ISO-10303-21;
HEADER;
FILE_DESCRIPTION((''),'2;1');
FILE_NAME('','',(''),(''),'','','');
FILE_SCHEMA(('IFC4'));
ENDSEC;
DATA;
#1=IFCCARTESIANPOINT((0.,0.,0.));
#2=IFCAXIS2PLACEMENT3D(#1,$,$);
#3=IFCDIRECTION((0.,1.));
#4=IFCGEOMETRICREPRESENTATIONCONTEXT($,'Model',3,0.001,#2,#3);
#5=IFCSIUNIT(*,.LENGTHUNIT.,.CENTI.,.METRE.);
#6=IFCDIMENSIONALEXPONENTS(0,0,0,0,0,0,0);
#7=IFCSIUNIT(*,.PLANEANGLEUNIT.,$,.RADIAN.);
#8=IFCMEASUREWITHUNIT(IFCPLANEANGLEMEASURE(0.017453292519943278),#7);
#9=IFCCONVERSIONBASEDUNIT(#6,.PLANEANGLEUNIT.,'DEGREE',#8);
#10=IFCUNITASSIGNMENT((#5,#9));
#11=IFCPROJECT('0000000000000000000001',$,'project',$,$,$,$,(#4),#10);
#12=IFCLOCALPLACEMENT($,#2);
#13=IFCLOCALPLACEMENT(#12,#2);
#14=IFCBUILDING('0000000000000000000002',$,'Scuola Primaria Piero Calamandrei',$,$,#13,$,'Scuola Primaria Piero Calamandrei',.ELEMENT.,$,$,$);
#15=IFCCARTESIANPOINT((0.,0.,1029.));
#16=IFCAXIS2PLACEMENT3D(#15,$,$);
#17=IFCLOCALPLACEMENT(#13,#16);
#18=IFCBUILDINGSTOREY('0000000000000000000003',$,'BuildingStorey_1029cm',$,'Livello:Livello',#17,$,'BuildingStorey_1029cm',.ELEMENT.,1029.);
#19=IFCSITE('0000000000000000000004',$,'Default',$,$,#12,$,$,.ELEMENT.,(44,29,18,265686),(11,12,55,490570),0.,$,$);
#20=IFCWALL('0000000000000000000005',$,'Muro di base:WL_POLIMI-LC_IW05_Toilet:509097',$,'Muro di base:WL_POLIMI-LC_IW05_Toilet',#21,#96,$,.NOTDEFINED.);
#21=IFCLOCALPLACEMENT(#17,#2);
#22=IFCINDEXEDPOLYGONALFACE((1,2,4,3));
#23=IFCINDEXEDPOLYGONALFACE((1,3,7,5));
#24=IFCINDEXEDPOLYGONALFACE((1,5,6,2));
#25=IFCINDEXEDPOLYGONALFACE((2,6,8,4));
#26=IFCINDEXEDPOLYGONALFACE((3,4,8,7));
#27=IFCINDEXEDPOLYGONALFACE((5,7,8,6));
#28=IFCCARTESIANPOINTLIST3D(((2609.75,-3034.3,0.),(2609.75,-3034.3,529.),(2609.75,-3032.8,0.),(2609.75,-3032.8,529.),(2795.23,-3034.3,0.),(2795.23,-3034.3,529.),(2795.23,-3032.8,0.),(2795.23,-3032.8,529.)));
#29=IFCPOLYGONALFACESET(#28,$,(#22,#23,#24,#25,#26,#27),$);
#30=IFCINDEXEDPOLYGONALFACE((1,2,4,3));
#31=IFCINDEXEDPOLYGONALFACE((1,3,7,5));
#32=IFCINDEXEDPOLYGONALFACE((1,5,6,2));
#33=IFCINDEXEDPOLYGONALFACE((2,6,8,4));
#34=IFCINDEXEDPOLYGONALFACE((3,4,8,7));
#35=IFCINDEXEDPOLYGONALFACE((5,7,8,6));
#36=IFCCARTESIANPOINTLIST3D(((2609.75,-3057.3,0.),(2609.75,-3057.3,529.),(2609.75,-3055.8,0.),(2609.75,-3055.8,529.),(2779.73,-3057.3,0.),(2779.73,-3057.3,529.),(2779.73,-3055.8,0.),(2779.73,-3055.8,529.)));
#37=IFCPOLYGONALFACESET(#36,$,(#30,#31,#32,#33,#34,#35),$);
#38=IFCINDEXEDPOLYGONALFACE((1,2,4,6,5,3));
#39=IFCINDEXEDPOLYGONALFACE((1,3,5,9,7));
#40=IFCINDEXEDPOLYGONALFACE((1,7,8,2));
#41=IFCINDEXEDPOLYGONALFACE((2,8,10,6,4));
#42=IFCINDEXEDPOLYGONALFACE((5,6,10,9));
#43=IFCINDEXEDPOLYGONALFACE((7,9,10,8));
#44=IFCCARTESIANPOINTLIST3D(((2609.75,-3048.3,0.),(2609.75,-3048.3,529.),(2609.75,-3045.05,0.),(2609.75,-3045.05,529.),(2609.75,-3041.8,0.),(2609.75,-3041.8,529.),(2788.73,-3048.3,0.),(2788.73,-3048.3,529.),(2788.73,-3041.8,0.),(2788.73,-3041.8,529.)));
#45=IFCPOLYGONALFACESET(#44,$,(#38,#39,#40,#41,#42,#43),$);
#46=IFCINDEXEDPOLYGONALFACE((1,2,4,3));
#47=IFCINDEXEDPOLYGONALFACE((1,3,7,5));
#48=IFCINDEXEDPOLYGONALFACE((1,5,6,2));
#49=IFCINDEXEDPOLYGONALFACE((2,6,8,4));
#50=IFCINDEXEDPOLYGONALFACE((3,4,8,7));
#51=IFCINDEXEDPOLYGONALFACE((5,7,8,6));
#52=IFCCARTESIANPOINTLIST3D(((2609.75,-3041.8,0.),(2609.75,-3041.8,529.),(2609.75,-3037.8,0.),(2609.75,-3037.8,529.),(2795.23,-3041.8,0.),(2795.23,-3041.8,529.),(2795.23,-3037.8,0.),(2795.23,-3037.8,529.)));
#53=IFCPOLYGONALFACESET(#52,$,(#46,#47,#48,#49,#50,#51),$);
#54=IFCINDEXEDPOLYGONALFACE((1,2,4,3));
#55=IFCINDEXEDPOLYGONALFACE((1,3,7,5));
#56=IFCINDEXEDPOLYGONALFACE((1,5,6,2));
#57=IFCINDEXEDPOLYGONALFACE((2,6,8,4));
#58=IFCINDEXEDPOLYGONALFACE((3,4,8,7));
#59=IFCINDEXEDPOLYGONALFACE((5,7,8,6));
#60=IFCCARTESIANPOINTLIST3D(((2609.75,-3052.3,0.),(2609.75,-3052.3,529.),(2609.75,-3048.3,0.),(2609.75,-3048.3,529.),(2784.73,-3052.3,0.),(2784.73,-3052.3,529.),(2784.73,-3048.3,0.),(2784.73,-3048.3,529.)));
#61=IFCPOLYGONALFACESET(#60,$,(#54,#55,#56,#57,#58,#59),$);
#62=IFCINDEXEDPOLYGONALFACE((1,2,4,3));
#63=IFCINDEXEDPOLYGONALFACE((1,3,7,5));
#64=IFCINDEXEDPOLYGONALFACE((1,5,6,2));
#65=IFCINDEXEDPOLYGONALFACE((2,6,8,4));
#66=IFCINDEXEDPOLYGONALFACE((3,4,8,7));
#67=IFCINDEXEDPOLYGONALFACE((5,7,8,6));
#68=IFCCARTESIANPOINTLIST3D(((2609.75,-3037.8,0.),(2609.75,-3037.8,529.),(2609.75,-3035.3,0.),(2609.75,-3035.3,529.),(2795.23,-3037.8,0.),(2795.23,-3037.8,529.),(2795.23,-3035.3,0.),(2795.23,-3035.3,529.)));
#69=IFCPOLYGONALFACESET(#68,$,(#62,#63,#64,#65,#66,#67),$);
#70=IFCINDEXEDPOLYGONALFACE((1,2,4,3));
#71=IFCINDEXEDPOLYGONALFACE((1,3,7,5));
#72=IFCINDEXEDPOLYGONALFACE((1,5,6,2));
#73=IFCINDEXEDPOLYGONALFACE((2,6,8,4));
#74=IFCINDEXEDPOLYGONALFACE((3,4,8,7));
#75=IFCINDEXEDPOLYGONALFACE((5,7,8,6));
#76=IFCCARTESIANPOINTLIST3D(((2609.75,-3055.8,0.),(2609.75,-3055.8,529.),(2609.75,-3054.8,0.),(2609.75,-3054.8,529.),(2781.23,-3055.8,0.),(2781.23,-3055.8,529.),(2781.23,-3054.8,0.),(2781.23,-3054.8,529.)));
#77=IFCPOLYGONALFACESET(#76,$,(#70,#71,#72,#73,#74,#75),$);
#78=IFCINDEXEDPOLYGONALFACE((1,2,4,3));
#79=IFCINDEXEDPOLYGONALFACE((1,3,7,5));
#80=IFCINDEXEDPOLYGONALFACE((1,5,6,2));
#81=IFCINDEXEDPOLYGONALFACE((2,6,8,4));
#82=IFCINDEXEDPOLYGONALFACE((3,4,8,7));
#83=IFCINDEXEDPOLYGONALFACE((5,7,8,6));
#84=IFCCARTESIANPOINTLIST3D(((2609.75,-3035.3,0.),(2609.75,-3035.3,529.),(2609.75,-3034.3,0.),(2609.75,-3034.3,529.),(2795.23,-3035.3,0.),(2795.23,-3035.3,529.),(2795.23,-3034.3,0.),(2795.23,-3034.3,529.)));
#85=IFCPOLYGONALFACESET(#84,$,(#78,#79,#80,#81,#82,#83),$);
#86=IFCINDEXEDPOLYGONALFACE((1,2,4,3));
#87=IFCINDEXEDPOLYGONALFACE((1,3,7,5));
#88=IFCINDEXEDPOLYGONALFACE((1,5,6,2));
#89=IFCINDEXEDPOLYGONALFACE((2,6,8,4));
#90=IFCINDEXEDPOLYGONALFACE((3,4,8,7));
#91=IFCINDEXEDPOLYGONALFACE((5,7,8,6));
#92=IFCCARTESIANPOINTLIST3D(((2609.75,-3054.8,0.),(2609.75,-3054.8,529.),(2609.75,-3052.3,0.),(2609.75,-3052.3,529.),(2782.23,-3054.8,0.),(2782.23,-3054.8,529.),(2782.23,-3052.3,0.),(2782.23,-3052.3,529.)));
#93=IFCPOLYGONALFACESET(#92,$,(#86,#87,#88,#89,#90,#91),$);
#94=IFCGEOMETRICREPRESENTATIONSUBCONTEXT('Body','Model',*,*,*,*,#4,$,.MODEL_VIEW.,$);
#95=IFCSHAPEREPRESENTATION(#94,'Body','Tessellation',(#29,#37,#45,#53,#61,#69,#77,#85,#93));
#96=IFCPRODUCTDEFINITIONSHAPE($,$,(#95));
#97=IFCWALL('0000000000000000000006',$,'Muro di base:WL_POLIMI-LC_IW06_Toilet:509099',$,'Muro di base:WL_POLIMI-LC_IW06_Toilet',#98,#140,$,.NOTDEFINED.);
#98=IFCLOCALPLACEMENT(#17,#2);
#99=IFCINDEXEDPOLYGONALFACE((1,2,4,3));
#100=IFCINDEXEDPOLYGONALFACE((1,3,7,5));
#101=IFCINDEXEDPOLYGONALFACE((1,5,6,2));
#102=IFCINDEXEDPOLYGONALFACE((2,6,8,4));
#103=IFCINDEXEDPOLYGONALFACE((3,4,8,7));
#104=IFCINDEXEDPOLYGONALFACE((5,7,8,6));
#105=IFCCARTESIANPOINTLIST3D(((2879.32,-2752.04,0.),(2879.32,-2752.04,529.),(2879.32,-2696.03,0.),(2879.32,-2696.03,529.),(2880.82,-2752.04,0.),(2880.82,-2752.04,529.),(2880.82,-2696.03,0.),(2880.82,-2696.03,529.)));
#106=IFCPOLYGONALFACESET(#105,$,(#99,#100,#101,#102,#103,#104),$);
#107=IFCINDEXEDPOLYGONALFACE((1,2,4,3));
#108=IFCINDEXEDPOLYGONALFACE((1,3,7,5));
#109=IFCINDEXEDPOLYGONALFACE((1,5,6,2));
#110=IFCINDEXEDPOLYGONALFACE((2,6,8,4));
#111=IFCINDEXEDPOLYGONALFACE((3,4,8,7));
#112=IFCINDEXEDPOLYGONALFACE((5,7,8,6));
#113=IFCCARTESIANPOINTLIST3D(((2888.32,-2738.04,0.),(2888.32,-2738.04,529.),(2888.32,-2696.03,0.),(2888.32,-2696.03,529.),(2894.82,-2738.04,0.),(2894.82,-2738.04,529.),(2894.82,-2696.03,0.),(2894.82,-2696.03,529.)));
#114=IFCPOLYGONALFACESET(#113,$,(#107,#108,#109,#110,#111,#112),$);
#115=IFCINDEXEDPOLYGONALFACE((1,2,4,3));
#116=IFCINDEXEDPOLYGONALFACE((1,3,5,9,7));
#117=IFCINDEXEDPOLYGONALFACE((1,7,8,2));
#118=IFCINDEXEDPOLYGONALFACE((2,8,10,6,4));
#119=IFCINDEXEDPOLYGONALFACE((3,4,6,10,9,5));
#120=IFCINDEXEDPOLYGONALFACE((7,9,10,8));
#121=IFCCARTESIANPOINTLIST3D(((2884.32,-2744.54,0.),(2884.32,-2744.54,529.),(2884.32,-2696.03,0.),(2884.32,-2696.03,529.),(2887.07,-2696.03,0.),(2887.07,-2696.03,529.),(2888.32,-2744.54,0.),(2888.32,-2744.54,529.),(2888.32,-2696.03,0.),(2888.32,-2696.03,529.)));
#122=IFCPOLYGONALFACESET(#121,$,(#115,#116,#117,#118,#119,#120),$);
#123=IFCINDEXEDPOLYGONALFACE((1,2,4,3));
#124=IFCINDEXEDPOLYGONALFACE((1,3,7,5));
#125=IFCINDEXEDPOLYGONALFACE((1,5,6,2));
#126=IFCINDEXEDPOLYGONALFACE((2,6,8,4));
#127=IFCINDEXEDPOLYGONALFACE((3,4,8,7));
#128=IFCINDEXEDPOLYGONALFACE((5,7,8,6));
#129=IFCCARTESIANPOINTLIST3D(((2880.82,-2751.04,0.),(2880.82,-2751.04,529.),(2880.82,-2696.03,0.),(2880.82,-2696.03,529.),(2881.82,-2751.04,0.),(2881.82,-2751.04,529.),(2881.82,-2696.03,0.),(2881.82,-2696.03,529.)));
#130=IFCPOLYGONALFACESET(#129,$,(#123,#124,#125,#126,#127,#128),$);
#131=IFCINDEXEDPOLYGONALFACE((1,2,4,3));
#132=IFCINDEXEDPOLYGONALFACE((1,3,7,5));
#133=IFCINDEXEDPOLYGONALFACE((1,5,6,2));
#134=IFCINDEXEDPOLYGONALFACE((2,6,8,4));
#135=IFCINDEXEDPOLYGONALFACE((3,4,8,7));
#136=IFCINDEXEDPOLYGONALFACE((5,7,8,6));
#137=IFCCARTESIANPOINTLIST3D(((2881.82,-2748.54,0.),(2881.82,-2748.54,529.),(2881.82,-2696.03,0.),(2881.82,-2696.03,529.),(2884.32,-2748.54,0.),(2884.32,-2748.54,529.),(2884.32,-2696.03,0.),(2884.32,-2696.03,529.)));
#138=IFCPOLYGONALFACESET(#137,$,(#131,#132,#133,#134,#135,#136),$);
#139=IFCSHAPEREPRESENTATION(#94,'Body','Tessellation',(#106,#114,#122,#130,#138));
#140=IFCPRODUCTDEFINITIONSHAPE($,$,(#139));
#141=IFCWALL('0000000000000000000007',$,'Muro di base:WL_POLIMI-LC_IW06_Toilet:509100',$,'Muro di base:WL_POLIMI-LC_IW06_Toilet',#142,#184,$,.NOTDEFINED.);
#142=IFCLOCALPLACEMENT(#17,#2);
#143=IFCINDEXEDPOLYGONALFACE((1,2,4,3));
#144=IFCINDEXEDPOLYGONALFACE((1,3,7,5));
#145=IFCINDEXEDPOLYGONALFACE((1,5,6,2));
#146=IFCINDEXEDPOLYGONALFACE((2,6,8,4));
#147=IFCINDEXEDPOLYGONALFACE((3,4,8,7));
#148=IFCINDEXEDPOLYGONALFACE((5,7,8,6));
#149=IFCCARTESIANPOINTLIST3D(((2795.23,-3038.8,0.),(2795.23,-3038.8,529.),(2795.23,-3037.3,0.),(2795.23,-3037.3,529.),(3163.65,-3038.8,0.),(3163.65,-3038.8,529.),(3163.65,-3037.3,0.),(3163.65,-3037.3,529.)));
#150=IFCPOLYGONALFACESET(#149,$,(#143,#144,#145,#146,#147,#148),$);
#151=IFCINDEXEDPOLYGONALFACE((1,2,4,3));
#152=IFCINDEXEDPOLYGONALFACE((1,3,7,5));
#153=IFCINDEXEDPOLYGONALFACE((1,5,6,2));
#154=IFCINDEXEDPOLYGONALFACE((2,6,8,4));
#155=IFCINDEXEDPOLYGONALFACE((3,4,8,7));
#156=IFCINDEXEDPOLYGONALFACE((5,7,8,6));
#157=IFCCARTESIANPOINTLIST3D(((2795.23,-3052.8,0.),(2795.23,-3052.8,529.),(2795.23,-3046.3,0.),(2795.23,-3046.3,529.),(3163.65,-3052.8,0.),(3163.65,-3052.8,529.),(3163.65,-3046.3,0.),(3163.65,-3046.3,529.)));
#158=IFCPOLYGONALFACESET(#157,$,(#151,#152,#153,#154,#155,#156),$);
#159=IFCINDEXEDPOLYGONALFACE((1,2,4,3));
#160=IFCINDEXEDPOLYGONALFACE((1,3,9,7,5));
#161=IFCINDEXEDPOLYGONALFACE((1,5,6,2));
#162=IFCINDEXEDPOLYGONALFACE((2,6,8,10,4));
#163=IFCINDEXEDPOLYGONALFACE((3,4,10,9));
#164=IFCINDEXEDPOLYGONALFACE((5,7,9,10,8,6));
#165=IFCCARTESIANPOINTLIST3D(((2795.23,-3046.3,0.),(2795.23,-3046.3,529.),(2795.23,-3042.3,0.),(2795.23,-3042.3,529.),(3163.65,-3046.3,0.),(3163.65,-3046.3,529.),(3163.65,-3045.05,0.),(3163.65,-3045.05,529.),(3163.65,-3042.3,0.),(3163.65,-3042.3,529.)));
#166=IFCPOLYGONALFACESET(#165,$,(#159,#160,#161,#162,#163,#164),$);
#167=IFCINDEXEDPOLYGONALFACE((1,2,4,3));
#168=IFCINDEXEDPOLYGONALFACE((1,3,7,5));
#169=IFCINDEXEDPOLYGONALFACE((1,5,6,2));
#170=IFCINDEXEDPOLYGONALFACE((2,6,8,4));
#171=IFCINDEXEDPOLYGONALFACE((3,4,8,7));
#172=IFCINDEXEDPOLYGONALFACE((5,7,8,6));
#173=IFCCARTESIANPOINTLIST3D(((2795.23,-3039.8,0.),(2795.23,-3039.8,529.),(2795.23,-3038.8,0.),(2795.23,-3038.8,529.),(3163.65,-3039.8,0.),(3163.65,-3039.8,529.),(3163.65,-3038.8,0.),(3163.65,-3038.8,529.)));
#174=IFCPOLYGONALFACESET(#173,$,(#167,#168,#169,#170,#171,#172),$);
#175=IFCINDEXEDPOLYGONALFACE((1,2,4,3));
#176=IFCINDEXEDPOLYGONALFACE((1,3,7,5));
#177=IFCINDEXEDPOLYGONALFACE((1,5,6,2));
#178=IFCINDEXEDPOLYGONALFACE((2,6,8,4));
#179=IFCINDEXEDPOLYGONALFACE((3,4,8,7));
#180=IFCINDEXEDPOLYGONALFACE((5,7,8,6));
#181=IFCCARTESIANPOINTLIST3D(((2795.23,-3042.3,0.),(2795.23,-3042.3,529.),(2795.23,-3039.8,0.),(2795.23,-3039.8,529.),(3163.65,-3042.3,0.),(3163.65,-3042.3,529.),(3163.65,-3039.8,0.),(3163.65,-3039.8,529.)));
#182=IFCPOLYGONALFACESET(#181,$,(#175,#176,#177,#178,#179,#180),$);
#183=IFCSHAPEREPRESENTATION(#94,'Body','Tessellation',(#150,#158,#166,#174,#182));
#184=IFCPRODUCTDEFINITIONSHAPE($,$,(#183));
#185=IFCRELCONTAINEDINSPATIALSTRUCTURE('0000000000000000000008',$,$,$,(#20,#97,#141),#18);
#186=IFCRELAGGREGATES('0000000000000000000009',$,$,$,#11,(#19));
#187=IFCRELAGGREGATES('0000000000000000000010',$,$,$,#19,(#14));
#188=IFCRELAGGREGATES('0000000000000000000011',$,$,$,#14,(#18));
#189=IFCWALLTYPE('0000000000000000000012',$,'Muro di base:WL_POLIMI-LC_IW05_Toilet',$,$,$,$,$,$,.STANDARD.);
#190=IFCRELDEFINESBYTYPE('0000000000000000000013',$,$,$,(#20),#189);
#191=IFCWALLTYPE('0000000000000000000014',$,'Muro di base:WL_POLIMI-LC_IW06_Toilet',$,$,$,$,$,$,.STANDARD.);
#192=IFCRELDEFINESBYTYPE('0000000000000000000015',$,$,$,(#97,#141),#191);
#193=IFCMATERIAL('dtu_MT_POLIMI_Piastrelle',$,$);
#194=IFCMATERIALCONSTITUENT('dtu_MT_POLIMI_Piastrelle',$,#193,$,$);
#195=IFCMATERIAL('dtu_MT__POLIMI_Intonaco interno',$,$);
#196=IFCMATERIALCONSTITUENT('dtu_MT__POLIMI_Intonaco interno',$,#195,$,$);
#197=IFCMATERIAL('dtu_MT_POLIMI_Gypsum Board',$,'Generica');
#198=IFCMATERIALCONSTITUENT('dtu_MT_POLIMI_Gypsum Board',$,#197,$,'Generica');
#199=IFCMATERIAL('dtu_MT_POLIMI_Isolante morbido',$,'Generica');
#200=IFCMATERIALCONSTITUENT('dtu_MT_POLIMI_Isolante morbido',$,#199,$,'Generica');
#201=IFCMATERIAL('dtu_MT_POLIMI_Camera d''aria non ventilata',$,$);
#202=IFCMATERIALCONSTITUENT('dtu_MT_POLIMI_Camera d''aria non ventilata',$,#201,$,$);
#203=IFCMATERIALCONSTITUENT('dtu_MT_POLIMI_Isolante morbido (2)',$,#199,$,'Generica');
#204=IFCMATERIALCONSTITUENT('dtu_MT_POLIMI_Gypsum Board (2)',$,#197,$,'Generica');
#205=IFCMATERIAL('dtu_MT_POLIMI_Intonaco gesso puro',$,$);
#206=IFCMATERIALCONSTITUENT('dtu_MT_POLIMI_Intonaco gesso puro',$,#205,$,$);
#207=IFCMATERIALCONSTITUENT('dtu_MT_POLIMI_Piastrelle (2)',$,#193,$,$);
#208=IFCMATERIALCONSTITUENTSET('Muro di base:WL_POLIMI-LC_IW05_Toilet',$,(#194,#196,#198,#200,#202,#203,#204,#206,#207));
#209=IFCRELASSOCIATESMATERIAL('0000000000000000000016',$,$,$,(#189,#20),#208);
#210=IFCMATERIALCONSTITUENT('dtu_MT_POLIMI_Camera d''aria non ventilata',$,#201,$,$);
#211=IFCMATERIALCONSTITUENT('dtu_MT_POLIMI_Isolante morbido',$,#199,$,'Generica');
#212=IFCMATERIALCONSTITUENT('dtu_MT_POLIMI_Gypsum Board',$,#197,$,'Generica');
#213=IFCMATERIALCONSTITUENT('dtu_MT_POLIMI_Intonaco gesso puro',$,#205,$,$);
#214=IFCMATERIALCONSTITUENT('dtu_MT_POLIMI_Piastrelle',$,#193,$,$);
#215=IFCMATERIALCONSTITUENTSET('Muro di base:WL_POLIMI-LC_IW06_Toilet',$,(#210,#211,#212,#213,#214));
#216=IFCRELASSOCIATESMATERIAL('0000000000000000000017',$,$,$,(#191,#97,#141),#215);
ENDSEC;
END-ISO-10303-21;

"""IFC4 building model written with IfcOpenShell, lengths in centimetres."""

from ifc_helpers import new_model, entity, si_unit, converted_unit, direction, frame, origin, place, context, subcontext, project, spatial, indexed_curve, outline, extrude, material, constituent, constituent_set, type_object, element, save


model = new_model("IFC4")

# Units and contexts
model_context = context("Model", 3, precision=0.001, world=origin(), true_north=direction((0.0, 1.0)))
body_context = subcontext(model_context, "Body", "Model", "MODEL_VIEW")
ifc_project = project(units=[si_unit("LENGTHUNIT", "METRE", prefix="CENTI"), converted_unit("PLANEANGLEUNIT", "DEGREE", entity("IfcPlaneAngleMeasure", 0.017453292519943278), si_unit("PLANEANGLEUNIT", "RADIAN"), dimensions=[0, 0, 0, 0, 0, 0, 0])], contexts=[model_context])

# Site, building, storey
site_placement = place(None, origin())
site = spatial("IfcSite", under=ifc_project, at=site_placement, Name="Default", CompositionType="ELEMENT", RefLatitude=(44, 29, 18, 265686), RefLongitude=(11, 12, 55, 490570), RefElevation=0.0)
building_placement = place(site_placement, origin())
building = spatial("IfcBuilding", under=site, at=building_placement, Name="Scuola Primaria Piero Calamandrei", LongName="Scuola Primaria Piero Calamandrei", CompositionType="ELEMENT")
storey_placement = place(building_placement, frame((0.0, 0.0, 1029.0)))
storey = spatial("IfcBuildingStorey", under=building, at=storey_placement, Name="BuildingStorey_1029cm", ObjectType="Livello:Livello", LongName="BuildingStorey_1029cm", CompositionType="ELEMENT", Elevation=1029.0)

# Shared definitions
ifc_material_1 = material(Name="dtu_MT_POLIMI_Isolante morbido", Category="Generica")
ifc_material_2 = material(Name="dtu_MT_POLIMI_Gypsum Board", Category="Generica")
ifc_material_3 = material(Name="dtu_MT__POLIMI_Intonaco interno")

# Shared definitions
ifc_material_4 = material(Name="dtu_MT_POLIMI_Camera d'aria non ventilata")
ifc_material_5 = material(Name="dtu_MT_POLIMI_Intonaco gesso puro")

# Shared definitions
ifc_material_6 = material(Name="dtu_MT_POLIMI_Piastrelle")

# Walls
ifc_constituent_1 = constituent(ifc_material_6, Name="dtu_MT_POLIMI_Piastrelle")
ifc_constituent_2 = constituent(ifc_material_3, Name="dtu_MT__POLIMI_Intonaco interno")
ifc_constituent_3 = constituent(ifc_material_2, Name="dtu_MT_POLIMI_Gypsum Board", Category="Generica")
ifc_constituent_4 = constituent(ifc_material_1, Name="dtu_MT_POLIMI_Isolante morbido", Category="Generica")
ifc_constituent_5 = constituent(ifc_material_4, Name="dtu_MT_POLIMI_Camera d'aria non ventilata")
ifc_constituent_6 = constituent(ifc_material_1, Name="dtu_MT_POLIMI_Isolante morbido (2)", Category="Generica")
ifc_constituent_7 = constituent(ifc_material_2, Name="dtu_MT_POLIMI_Gypsum Board (2)", Category="Generica")
ifc_constituent_8 = constituent(ifc_material_5, Name="dtu_MT_POLIMI_Intonaco gesso puro")
ifc_constituent_9 = constituent(ifc_material_6, Name="dtu_MT_POLIMI_Piastrelle (2)")
ifc_constituent_set_1 = constituent_set(constituents=[ifc_constituent_1, ifc_constituent_2, ifc_constituent_3, ifc_constituent_4, ifc_constituent_5, ifc_constituent_6, ifc_constituent_7, ifc_constituent_8, ifc_constituent_9], Name="Muro di base:WL_POLIMI-LC_IW05_Toilet")
wall_type_1 = type_object("IfcWallType", Name="Muro di base:WL_POLIMI-LC_IW05_Toilet", PredefinedType="STANDARD", material=ifc_constituent_set_1)
wall_1_placement = place(storey_placement, frame((2609.75, -3045.05, 0.0)))
element("IfcWall", 1, at=wall_1_placement, inside=storey, type_object=wall_type_1, material=ifc_constituent_set_1, Name="Muro di base:WL_POLIMI-LC_IW05_Toilet:509097", ObjectType="Muro di base:WL_POLIMI-LC_IW05_Toilet", PredefinedType="NOTDEFINED", context=body_context, shape_type="SweptSolid", body=[
    extrude(outline(indexed_curve([(-0.75, -92.74), (0.75, -92.74), (0.75, 92.74), (-0.75, 92.74), (-0.75, -92.74)], self_intersect=False)), frame((92.74, 11.5, 0.0), z_axis=(0.0, 0.0, 1.0), x_axis=(0.0, -1.0, 0.0)), (0.0, 0.0, 1.0), 529.0),
    extrude(outline(indexed_curve([(-0.75, -84.99), (0.75, -84.99), (0.75, 84.99), (-0.75, 84.99), (-0.75, -84.99)], self_intersect=False)), frame((84.99, -11.5, 0.0), z_axis=(0.0, 0.0, 1.0), x_axis=(0.0, 1.0, 0.0)), (0.0, 0.0, 1.0), 529.0),
    extrude(outline(indexed_curve([(-71.59, -3.25), (107.39, -3.25), (107.39, 3.25), (-71.59, 3.25), (-71.59, 0.0), (-71.59, -3.25)], self_intersect=False)), frame((71.59, 0.0, 0.0)), (0.0, 0.0, 1.0), 529.0),
    extrude(outline(indexed_curve([(-92.74, -2.0), (92.74, -2.0), (92.74, 2.0), (-92.74, 2.0), (-92.74, -2.0)], self_intersect=False)), frame((92.74, 5.25, 0.0)), (0.0, 0.0, 1.0), 529.0),
    extrude(outline(indexed_curve([(-87.49, -2.0), (87.49, -2.0), (87.49, 2.0), (-87.49, 2.0), (-87.49, -2.0)], self_intersect=False)), frame((87.49, -5.25, 0.0)), (0.0, 0.0, 1.0), 529.0),
    extrude(outline(indexed_curve([(-92.74, -1.25), (92.74, -1.25), (92.74, 1.25), (-92.74, 1.25), (-92.74, -1.25)], self_intersect=False)), frame((92.74, 8.5, 0.0)), (0.0, 0.0, 1.0), 529.0),
    extrude(outline(indexed_curve([(-85.74, -0.5), (85.74, -0.5), (85.74, 0.5), (-85.74, 0.5), (-85.74, -0.5)], self_intersect=False)), frame((85.74, -10.25, 0.0)), (0.0, 0.0, 1.0), 529.0),
    extrude(outline(indexed_curve([(-92.74, -0.5), (92.74, -0.5), (92.74, 0.5), (-92.74, 0.5), (-92.74, -0.5)], self_intersect=False)), frame((92.74, 10.25, 0.0)), (0.0, 0.0, 1.0), 529.0),
    extrude(outline(indexed_curve([(-86.24, -1.25), (86.24, -1.25), (86.24, 1.25), (-86.24, 1.25), (-86.24, -1.25)], self_intersect=False)), frame((86.24, -8.5, 0.0)), (0.0, 0.0, 1.0), 529.0),
])
ifc_constituent_10 = constituent(ifc_material_4, Name="dtu_MT_POLIMI_Camera d'aria non ventilata")
ifc_constituent_11 = constituent(ifc_material_1, Name="dtu_MT_POLIMI_Isolante morbido", Category="Generica")
ifc_constituent_12 = constituent(ifc_material_2, Name="dtu_MT_POLIMI_Gypsum Board", Category="Generica")
ifc_constituent_13 = constituent(ifc_material_5, Name="dtu_MT_POLIMI_Intonaco gesso puro")
ifc_constituent_14 = constituent(ifc_material_6, Name="dtu_MT_POLIMI_Piastrelle")
ifc_constituent_set_2 = constituent_set(constituents=[ifc_constituent_10, ifc_constituent_11, ifc_constituent_12, ifc_constituent_13, ifc_constituent_14], Name="Muro di base:WL_POLIMI-LC_IW06_Toilet")
wall_type_2 = type_object("IfcWallType", Name="Muro di base:WL_POLIMI-LC_IW06_Toilet", PredefinedType="STANDARD", material=ifc_constituent_set_2)
wall_2_placement = place(storey_placement, frame((2887.07, -2696.03, 0.0), z_axis=(0.0, 0.0, 1.0), x_axis=(0.0, -1.0, 0.0)))
element("IfcWall", 2, at=wall_2_placement, inside=storey, type_object=wall_type_2, material=ifc_constituent_set_2, Name="Muro di base:WL_POLIMI-LC_IW06_Toilet:509099", ObjectType="Muro di base:WL_POLIMI-LC_IW06_Toilet", PredefinedType="NOTDEFINED", context=body_context, shape_type="SweptSolid", body=[
    extrude(outline(indexed_curve([(-0.75, -28.0), (0.75, -28.0), (0.75, 28.0), (-0.75, 28.0), (-0.75, -28.0)], self_intersect=False)), frame((28.0, -7.0, 0.0), z_axis=(0.0, 0.0, 1.0), x_axis=(0.0, 1.0, 0.0)), (0.0, 0.0, 1.0), 529.0),
    extrude(outline(indexed_curve([(-3.25, -21.0), (3.25, -21.0), (3.25, 21.0), (-3.25, 21.0), (-3.25, -21.0)], self_intersect=False)), frame((21.0, 4.5, 0.0), z_axis=(0.0, 0.0, 1.0), x_axis=(0.0, -1.0, 0.0)), (0.0, 0.0, 1.0), 529.0),
    extrude(outline(indexed_curve([(-19.4, -2.15), (29.1, -2.15), (29.1, 1.85), (-19.4, 1.85), (-19.4, 0.6), (-19.4, -2.15)], self_intersect=False)), frame((19.4, -0.6, 0.0)), (0.0, 0.0, 1.0), 529.0),
    extrude(outline(indexed_curve([(-27.5, -0.5), (27.5, -0.5), (27.5, 0.5), (-27.5, 0.5), (-27.5, -0.5)], self_intersect=False)), frame((27.5, -5.75, 0.0)), (0.0, 0.0, 1.0), 529.0),
    extrude(outline(indexed_curve([(-26.25, -1.25), (26.25, -1.25), (26.25, 1.25), (-26.25, 1.25), (-26.25, -1.25)], self_intersect=False)), frame((26.25, -4.0, 0.0)), (0.0, 0.0, 1.0), 529.0),
])
wall_3_placement = place(storey_placement, frame((3163.65, -3045.05, 0.0), z_axis=(0.0, 0.0, 1.0), x_axis=(-1.0, 0.0, 0.0)))
element("IfcWall", 3, at=wall_3_placement, inside=storey, type_object=wall_type_2, material=ifc_constituent_set_2, Name="Muro di base:WL_POLIMI-LC_IW06_Toilet:509100", ObjectType="Muro di base:WL_POLIMI-LC_IW06_Toilet", PredefinedType="NOTDEFINED", context=body_context, shape_type="SweptSolid", body=[
    extrude(outline(indexed_curve([(-0.75, -184.21), (0.75, -184.21), (0.75, 184.21), (-0.75, 184.21), (-0.75, -184.21)], self_intersect=False)), frame((184.21, -7.0, 0.0), z_axis=(0.0, 0.0, 1.0), x_axis=(0.0, 1.0, 0.0)), (0.0, 0.0, 1.0), 529.0),
    extrude(outline(indexed_curve([(-3.25, -184.21), (3.25, -184.21), (3.25, 184.21), (-3.25, 184.21), (-3.25, -184.21)], self_intersect=False)), frame((184.21, 4.5, 0.0), z_axis=(0.0, 0.0, 1.0), x_axis=(0.0, -1.0, 0.0)), (0.0, 0.0, 1.0), 529.0),
    extrude(outline(indexed_curve([(-147.37, -2.15), (221.05, -2.15), (221.05, 1.85), (-147.37, 1.85), (-147.37, 0.6), (-147.37, -2.15)], self_intersect=False)), frame((147.37, -0.6, 0.0)), (0.0, 0.0, 1.0), 529.0),
    extrude(outline(indexed_curve([(-184.21, -0.5), (184.21, -0.5), (184.21, 0.5), (-184.21, 0.5), (-184.21, -0.5)], self_intersect=False)), frame((184.21, -5.75, 0.0)), (0.0, 0.0, 1.0), 529.0),
    extrude(outline(indexed_curve([(-184.21, -1.25), (184.21, -1.25), (184.21, 1.25), (-184.21, 1.25), (-184.21, -1.25)], self_intersect=False)), frame((184.21, -4.0, 0.0)), (0.0, 0.0, 1.0), 529.0),
])

save(model, "model.ifc")
